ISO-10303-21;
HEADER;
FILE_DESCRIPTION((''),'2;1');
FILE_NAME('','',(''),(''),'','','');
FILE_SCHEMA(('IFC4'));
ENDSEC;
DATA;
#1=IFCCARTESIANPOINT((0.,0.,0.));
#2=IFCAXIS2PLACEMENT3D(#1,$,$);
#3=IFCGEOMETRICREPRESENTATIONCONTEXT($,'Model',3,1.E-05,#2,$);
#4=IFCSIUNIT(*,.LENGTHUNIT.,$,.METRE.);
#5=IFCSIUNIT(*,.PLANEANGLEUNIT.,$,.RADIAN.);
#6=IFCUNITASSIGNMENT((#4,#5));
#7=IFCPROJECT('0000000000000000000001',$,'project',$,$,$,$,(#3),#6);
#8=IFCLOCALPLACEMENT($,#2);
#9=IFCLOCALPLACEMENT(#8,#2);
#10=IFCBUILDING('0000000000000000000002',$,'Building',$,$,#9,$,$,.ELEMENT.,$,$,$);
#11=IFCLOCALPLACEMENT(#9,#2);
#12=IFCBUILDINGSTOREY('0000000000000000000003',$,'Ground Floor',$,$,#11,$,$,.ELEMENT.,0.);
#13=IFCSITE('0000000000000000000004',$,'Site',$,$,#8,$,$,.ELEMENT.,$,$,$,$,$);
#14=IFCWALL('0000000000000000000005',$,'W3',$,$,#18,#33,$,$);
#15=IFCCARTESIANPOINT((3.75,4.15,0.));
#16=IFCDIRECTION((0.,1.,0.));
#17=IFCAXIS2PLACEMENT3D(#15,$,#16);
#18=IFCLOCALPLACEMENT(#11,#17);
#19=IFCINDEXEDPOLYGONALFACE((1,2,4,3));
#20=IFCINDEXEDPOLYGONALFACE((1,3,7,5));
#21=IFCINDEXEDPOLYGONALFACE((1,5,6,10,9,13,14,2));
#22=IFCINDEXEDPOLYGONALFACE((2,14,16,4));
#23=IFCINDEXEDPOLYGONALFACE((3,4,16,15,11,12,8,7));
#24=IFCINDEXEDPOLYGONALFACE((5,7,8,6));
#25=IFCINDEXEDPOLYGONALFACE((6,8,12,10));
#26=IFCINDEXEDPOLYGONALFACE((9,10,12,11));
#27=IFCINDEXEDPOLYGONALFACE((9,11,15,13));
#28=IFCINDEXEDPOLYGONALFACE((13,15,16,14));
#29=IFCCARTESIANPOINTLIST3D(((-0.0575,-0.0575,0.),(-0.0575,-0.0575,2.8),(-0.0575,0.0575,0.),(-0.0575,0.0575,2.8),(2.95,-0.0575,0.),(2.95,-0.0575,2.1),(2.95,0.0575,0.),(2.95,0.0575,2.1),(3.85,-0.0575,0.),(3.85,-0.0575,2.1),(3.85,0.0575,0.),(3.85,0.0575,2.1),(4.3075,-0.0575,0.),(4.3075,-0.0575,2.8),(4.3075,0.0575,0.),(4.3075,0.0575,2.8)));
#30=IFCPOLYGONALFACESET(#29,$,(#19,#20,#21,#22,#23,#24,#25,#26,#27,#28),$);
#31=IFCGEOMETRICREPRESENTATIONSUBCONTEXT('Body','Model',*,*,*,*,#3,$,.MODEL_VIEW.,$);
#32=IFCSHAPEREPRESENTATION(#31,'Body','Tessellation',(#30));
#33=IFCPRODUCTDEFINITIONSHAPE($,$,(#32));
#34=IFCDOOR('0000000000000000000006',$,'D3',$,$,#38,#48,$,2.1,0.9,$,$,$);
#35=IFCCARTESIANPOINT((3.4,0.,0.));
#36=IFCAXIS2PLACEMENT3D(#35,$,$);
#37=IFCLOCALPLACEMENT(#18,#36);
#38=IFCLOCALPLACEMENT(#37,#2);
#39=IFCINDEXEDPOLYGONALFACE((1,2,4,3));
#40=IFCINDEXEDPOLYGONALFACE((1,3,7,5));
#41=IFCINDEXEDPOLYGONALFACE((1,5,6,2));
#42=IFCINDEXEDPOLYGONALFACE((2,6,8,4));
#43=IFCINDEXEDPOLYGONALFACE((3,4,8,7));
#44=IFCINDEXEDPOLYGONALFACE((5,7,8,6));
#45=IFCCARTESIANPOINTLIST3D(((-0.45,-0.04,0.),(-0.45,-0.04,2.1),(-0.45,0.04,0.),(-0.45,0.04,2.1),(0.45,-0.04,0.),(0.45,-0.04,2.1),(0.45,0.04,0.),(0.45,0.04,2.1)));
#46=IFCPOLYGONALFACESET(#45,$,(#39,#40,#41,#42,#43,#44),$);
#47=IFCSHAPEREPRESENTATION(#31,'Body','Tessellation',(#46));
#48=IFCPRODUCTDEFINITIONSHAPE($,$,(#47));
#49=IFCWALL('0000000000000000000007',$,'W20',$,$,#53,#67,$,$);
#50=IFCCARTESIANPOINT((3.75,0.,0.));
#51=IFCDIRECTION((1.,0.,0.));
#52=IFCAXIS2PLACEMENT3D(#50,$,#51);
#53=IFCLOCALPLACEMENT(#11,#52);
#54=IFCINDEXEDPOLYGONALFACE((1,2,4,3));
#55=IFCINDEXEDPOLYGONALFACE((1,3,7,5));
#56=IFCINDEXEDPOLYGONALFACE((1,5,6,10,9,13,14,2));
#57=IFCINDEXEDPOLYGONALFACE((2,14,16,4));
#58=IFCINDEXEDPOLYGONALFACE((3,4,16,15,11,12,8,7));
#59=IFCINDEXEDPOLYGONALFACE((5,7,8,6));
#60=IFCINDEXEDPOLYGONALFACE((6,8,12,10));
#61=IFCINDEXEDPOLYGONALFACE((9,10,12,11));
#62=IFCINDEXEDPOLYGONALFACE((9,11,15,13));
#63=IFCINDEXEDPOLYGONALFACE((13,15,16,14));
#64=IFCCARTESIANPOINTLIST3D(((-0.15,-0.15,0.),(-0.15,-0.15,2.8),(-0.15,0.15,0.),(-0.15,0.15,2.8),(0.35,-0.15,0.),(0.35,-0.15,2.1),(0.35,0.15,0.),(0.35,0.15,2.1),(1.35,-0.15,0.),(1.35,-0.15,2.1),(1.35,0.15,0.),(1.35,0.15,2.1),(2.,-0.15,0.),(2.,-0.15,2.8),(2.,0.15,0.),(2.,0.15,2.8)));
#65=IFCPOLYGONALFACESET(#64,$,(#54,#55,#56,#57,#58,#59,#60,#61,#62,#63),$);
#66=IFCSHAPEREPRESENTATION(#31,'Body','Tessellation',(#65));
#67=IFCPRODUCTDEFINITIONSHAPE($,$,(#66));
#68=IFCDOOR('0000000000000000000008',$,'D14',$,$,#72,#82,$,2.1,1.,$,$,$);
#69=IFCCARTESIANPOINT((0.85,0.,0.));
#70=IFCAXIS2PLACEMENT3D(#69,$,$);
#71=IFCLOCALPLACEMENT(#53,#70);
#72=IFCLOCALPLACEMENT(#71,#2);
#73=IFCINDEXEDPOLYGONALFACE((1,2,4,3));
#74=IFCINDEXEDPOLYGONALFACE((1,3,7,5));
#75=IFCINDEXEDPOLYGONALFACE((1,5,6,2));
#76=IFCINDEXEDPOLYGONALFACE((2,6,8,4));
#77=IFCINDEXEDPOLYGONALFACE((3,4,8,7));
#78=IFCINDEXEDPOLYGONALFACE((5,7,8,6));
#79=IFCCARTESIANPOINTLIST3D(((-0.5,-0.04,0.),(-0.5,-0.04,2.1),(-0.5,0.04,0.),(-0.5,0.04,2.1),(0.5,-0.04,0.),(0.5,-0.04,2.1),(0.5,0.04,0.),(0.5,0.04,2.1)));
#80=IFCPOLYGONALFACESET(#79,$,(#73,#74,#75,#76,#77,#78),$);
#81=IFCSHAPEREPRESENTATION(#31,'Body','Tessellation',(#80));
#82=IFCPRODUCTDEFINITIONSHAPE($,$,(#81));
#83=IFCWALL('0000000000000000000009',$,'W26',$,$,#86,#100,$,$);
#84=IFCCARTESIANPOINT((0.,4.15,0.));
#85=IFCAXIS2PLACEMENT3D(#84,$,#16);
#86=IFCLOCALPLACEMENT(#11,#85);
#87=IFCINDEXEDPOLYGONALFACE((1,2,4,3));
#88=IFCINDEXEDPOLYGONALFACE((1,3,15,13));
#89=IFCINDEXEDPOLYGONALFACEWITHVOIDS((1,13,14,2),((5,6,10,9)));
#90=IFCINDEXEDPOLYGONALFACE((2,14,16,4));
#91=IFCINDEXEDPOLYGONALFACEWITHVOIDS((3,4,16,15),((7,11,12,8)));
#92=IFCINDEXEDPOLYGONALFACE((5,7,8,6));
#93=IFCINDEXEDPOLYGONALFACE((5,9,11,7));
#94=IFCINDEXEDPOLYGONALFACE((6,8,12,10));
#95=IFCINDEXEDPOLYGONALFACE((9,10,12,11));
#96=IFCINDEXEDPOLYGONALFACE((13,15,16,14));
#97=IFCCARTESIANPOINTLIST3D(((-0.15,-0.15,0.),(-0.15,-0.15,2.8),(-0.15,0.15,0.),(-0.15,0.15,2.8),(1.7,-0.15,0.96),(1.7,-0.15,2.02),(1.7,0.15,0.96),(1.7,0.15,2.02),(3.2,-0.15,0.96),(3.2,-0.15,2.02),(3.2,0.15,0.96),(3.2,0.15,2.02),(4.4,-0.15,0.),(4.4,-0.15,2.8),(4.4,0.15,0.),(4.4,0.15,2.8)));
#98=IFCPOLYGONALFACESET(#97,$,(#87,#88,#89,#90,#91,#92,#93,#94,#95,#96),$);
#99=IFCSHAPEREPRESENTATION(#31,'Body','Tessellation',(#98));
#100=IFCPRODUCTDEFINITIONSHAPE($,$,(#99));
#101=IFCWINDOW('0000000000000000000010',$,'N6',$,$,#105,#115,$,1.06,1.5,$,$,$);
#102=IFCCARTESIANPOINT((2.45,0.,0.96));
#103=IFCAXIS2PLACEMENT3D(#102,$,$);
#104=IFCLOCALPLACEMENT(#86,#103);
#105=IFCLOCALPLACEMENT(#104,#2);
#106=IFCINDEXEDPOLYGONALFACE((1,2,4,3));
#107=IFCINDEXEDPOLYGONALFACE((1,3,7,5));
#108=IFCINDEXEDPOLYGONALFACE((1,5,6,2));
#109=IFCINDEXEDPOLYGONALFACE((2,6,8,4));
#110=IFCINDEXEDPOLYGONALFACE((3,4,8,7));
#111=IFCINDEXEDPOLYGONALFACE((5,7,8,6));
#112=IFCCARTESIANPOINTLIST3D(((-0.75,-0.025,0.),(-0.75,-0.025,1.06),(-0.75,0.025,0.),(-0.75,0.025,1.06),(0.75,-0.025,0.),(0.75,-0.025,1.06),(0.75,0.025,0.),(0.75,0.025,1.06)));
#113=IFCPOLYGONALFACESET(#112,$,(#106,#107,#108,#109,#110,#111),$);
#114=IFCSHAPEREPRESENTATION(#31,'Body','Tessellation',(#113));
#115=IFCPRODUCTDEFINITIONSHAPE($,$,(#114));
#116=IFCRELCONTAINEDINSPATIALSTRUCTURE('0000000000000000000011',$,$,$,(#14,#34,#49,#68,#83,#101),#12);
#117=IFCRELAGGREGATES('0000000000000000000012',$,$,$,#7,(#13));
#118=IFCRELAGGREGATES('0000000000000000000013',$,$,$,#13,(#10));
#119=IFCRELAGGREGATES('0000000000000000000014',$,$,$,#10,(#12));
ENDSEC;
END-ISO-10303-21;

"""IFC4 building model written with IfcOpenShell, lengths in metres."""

from ifc_helpers import new_model, si_unit, frame, frame_2d, origin, origin_2d, place, context, subcontext, project, spatial, rectangle, extrude, element, fill, save


model = new_model("IFC4")

# Units and contexts
model_context = context("Model", 3, precision=1e-05, world=origin())
body_context = subcontext(model_context, "Body", "Model", "MODEL_VIEW")
ifc_project = project(units=[si_unit("LENGTHUNIT", "METRE"), si_unit("PLANEANGLEUNIT", "RADIAN")], contexts=[model_context])

# Site, building, storey
site_placement = place(None, origin())
site = spatial("IfcSite", under=ifc_project, at=site_placement, Name="Site", CompositionType="ELEMENT")
building_placement = place(site_placement, origin())
building = spatial("IfcBuilding", under=site, at=building_placement, Name="Building", CompositionType="ELEMENT")
storey_placement = place(building_placement, origin())
storey = spatial("IfcBuildingStorey", under=building, at=storey_placement, Name="Ground Floor", CompositionType="ELEMENT", Elevation=0.0)

# Walls, openings, doors
wall_1_placement = place(storey_placement, frame((3.75, 4.15, 0.0), x_axis=(0.0, 1.0, 0.0)))
wall_1 = element("IfcWall", 1, at=wall_1_placement, inside=storey, Name="W3", context=body_context, shape_type="SweptSolid", body=[
    extrude(rectangle(XDim=4.365, YDim=0.115, at=frame_2d((2.125, 0.0))), origin(), (0.0, 0.0, 1.0), 2.8),
])
opening_1_placement = place(wall_1_placement, frame((3.4, 0.0, 0.0)))
opening_1 = element("IfcOpeningElement", 2, at=opening_1_placement, cuts=wall_1, context=body_context, shape_type="SweptSolid", body=[
    extrude(rectangle(XDim=0.9, YDim=0.215, at=origin_2d()), origin(), (0.0, 0.0, 1.0), 2.1),
])
door_1_placement = place(opening_1_placement, origin())
door_1 = element("IfcDoor", 3, at=door_1_placement, inside=storey, Name="D3", OverallHeight=2.1, OverallWidth=0.9, context=body_context, shape_type="SweptSolid", body=[
    extrude(rectangle(XDim=0.9, YDim=0.08, at=origin_2d()), origin(), (0.0, 0.0, 1.0), 2.1),
])
fill(opening_1, door_1)
wall_2_placement = place(storey_placement, frame((3.75, 0.0, 0.0), x_axis=(1.0, 0.0, 0.0)))
wall_2 = element("IfcWall", 4, at=wall_2_placement, inside=storey, Name="W20", context=body_context, shape_type="SweptSolid", body=[
    extrude(rectangle(XDim=2.15, YDim=0.3, at=frame_2d((0.925, 0.0))), origin(), (0.0, 0.0, 1.0), 2.8),
])
opening_2_placement = place(wall_2_placement, frame((0.85, 0.0, 0.0)))
opening_2 = element("IfcOpeningElement", 5, at=opening_2_placement, cuts=wall_2, context=body_context, shape_type="SweptSolid", body=[
    extrude(rectangle(XDim=1.0, YDim=0.4, at=origin_2d()), origin(), (0.0, 0.0, 1.0), 2.1),
])
door_2_placement = place(opening_2_placement, origin())
door_2 = element("IfcDoor", 6, at=door_2_placement, inside=storey, Name="D14", OverallHeight=2.1, OverallWidth=1.0, context=body_context, shape_type="SweptSolid", body=[
    extrude(rectangle(XDim=1.0, YDim=0.08, at=origin_2d()), origin(), (0.0, 0.0, 1.0), 2.1),
])
fill(opening_2, door_2)

# Wall, opening, window
wall_3_placement = place(storey_placement, frame((0.0, 4.15, 0.0), x_axis=(0.0, 1.0, 0.0)))
wall_3 = element("IfcWall", 7, at=wall_3_placement, inside=storey, Name="W26", context=body_context, shape_type="SweptSolid", body=[
    extrude(rectangle(XDim=4.55, YDim=0.3, at=frame_2d((2.125, 0.0))), origin(), (0.0, 0.0, 1.0), 2.8),
])
opening_3_placement = place(wall_3_placement, frame((2.45, 0.0, 0.96)))
opening_3 = element("IfcOpeningElement", 8, at=opening_3_placement, cuts=wall_3, context=body_context, shape_type="SweptSolid", body=[
    extrude(rectangle(XDim=1.5, YDim=0.4, at=origin_2d()), origin(), (0.0, 0.0, 1.0), 1.06),
])
window_1_placement = place(opening_3_placement, origin())
window_1 = element("IfcWindow", 9, at=window_1_placement, inside=storey, Name="N6", OverallHeight=1.06, OverallWidth=1.5, context=body_context, shape_type="SweptSolid", body=[
    extrude(rectangle(XDim=1.5, YDim=0.05, at=origin_2d()), origin(), (0.0, 0.0, 1.0), 1.06),
])
fill(opening_3, window_1)

save(model, "model.ifc")
